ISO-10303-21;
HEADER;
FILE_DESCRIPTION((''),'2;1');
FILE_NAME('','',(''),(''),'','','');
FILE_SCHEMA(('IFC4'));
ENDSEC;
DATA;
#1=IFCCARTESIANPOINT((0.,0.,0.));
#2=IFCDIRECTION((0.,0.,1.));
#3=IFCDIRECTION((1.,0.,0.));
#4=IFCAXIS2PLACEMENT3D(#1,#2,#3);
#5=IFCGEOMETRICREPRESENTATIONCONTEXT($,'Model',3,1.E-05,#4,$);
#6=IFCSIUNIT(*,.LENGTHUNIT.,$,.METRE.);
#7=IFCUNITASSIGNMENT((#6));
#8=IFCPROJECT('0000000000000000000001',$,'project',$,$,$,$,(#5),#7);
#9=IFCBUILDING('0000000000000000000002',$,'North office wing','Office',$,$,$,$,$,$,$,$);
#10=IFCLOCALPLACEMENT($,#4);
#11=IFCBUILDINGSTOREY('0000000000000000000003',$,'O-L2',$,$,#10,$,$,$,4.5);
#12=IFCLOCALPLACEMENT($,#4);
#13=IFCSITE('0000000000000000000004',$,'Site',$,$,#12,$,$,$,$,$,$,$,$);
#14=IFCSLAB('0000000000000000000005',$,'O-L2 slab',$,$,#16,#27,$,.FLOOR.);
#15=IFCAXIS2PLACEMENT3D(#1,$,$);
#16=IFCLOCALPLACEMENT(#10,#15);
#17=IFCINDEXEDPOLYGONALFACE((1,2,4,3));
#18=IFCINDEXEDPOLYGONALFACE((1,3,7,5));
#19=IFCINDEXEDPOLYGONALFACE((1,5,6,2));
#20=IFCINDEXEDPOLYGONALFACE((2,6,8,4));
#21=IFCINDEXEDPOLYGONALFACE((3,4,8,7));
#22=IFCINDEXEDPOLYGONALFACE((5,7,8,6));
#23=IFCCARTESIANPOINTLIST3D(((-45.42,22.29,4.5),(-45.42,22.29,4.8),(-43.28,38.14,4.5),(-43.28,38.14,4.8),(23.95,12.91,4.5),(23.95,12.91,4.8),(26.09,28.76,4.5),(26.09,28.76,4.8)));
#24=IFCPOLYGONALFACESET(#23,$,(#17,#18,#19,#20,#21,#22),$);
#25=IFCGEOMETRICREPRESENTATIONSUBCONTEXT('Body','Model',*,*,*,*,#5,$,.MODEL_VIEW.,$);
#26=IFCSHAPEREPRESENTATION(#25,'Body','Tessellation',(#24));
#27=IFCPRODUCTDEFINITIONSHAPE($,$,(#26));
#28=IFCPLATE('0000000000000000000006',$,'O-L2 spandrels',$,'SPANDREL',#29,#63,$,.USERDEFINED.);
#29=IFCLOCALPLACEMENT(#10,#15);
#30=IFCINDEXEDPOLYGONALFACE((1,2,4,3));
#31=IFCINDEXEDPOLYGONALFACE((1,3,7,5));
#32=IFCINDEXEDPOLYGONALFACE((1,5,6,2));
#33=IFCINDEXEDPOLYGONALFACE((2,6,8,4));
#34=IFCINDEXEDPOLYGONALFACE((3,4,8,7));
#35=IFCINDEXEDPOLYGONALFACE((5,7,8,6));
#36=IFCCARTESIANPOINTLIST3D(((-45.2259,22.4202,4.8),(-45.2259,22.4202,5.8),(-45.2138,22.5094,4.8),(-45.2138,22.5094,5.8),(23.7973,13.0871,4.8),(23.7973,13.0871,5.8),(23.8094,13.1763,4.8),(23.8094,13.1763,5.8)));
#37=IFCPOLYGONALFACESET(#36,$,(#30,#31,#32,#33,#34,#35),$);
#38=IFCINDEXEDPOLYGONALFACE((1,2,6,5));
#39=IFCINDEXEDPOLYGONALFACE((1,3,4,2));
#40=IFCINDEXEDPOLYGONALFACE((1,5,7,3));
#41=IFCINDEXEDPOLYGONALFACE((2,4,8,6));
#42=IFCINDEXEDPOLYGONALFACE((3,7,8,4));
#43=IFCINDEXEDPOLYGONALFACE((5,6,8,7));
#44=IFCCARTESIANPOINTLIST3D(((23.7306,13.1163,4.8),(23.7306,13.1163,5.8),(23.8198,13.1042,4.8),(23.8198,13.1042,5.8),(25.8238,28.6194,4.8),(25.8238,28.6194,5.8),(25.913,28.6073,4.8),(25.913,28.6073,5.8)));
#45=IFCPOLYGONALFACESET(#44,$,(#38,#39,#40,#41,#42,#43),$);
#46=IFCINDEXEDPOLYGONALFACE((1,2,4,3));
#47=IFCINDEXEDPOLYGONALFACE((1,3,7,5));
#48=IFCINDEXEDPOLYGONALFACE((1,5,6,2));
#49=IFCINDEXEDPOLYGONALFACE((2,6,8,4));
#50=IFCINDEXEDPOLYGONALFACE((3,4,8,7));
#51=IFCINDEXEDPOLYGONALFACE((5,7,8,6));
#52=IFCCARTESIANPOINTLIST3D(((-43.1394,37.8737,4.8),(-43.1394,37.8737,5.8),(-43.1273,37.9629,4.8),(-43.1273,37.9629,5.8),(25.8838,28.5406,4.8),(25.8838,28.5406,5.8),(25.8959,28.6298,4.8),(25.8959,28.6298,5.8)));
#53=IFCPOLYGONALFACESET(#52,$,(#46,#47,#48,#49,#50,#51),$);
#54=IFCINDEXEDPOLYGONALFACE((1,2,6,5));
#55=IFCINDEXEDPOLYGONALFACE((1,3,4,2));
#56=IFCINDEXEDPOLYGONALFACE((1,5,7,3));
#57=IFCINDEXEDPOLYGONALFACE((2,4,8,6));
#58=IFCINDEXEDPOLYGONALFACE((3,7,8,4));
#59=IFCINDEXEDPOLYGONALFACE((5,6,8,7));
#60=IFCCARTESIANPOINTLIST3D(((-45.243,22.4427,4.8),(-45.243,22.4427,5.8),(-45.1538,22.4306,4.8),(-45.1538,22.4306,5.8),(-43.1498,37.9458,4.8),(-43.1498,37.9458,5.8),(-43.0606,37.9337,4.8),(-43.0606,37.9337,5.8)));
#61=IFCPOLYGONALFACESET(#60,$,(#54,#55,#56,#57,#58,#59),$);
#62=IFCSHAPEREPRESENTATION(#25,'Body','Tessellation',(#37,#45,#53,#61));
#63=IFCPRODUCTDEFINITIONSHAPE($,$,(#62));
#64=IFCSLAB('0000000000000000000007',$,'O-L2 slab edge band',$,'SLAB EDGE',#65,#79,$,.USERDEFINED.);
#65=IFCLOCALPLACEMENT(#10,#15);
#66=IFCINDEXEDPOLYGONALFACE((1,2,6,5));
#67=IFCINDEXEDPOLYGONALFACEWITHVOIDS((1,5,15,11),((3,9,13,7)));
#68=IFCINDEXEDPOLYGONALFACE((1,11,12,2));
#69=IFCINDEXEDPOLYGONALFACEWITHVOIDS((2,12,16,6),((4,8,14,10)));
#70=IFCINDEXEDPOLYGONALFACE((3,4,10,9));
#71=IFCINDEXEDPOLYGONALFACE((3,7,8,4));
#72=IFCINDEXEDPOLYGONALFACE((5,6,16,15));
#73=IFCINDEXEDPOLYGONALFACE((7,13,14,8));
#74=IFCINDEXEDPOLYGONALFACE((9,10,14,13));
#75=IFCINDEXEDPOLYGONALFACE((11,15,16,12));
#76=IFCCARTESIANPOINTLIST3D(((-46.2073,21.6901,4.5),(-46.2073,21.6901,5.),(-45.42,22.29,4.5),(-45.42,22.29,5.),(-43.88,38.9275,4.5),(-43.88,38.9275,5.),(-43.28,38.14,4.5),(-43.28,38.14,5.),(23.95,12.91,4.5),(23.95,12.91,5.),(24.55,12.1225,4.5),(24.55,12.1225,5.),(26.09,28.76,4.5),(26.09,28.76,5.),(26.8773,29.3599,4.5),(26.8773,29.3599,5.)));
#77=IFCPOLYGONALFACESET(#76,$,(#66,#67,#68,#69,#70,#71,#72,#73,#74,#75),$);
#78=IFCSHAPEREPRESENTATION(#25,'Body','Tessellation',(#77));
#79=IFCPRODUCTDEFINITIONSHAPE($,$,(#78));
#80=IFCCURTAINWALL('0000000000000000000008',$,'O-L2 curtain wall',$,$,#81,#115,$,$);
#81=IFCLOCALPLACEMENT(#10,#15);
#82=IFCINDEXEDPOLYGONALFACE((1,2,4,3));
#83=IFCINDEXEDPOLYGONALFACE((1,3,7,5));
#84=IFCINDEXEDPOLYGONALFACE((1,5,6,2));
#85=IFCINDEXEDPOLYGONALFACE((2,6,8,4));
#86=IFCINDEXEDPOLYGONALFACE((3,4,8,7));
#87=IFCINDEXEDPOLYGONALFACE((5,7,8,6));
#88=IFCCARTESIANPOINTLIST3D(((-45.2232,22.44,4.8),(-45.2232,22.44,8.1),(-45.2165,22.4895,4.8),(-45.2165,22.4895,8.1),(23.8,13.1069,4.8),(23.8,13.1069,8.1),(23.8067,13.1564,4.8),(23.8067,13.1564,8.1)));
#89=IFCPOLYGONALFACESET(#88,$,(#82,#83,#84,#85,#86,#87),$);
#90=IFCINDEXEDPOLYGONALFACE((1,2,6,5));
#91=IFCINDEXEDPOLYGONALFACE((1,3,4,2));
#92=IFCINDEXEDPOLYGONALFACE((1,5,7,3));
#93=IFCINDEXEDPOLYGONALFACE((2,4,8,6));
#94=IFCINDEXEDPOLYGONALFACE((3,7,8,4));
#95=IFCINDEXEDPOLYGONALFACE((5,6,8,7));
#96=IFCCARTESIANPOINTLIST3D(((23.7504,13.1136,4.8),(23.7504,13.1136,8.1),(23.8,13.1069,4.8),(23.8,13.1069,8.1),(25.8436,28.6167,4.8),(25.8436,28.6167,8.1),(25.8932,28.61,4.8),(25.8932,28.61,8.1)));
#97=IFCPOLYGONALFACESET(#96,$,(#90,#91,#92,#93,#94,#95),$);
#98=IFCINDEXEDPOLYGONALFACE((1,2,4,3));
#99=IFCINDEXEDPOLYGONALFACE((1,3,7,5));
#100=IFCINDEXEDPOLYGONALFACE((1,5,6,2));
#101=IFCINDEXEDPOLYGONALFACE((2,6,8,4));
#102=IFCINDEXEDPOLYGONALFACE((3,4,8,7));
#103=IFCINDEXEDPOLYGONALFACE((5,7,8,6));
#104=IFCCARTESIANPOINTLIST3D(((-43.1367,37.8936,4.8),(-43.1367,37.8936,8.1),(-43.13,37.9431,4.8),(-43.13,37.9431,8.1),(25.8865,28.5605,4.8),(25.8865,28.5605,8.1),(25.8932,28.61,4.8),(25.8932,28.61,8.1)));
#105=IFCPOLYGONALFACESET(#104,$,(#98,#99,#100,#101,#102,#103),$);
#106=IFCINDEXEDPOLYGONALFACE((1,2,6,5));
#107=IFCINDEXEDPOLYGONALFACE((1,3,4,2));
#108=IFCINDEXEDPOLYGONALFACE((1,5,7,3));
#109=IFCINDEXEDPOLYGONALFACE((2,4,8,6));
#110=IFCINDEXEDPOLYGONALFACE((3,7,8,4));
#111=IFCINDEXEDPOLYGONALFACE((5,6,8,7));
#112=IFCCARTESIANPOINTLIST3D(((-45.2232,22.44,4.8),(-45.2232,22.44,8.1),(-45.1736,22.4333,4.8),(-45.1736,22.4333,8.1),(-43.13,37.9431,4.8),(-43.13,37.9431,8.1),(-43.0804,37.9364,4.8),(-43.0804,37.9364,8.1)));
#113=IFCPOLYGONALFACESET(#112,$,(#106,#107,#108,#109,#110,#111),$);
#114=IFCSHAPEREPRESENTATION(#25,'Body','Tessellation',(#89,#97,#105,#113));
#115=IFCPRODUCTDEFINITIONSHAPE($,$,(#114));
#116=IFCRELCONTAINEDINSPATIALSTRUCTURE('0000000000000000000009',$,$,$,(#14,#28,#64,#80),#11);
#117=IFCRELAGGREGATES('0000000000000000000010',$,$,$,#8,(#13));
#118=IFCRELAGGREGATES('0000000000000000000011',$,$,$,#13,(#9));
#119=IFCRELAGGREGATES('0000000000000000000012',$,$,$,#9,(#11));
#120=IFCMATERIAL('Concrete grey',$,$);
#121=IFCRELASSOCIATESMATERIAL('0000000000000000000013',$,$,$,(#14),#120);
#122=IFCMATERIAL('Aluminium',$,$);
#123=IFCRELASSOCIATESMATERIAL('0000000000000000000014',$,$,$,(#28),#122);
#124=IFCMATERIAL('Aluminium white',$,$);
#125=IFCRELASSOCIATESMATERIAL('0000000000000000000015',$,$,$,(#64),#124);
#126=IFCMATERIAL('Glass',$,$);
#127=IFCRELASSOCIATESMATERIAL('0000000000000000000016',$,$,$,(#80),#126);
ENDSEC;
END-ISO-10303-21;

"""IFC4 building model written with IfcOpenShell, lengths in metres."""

from ifc_helpers import new_model, si_unit, frame, origin_with_axes, place, context, subcontext, project, spatial, polyline, outline, extrude, material, element, save


model = new_model("IFC4")

# Units and contexts
model_context = context("Model", 3, precision=1e-05, world=origin_with_axes())
body_context = subcontext(model_context, "Body", "Model", "MODEL_VIEW")
ifc_project = project(units=[si_unit("LENGTHUNIT", "METRE")], contexts=[model_context])

# Site, building, storey
site_placement = place(None, origin_with_axes())
site = spatial("IfcSite", under=ifc_project, at=site_placement, Name="Site")
building = spatial("IfcBuilding", under=site, Name="North office wing", Description="Office")
storey_placement = place(None, origin_with_axes())
storey = spatial("IfcBuildingStorey", under=building, at=storey_placement, Name="O-L2", Elevation=4.5)

# Shared definitions
ifc_material_1 = material(Name="Aluminium")

# Slab
ifc_material_2 = material(Name="Concrete grey")
slab_1_placement = place(storey_placement, origin_with_axes())
element("IfcSlab", 1, at=slab_1_placement, inside=storey, material=ifc_material_2, Name="O-L2 slab", PredefinedType="FLOOR", context=body_context, shape_type="SweptSolid", body=[
    extrude(outline(polyline([(-45.42, 22.29), (23.95, 12.91), (26.09, 28.76), (-43.28, 38.14), (-45.42, 22.29)])), frame((0.0, 0.0, 4.5), z_axis=(0.0, 0.0, 1.0), x_axis=(1.0, 0.0, 0.0)), (0.0, 0.0, 1.0), 0.3),
])

# Plate
plate_placement = place(storey_placement, origin_with_axes())
element("IfcPlate", 2, at=plate_placement, inside=storey, material=ifc_material_1, Name="O-L2 spandrels", ObjectType="SPANDREL", PredefinedType="USERDEFINED", context=body_context, shape_type="SweptSolid", body=[
    extrude(outline(polyline([(-45.2259, 22.4202), (23.7973, 13.0871), (23.8094, 13.1763), (-45.2138, 22.5094), (-45.2259, 22.4202)])), frame((0.0, 0.0, 4.8), z_axis=(0.0, 0.0, 1.0), x_axis=(1.0, 0.0, 0.0)), (0.0, 0.0, 1.0), 1.0),
    extrude(outline(polyline([(23.8198, 13.1042), (25.913, 28.6073), (25.8238, 28.6194), (23.7306, 13.1163), (23.8198, 13.1042)])), frame((0.0, 0.0, 4.8), z_axis=(0.0, 0.0, 1.0), x_axis=(1.0, 0.0, 0.0)), (0.0, 0.0, 1.0), 1.0),
    extrude(outline(polyline([(25.8959, 28.6298), (-43.1273, 37.9629), (-43.1394, 37.8737), (25.8838, 28.5406), (25.8959, 28.6298)])), frame((0.0, 0.0, 4.8), z_axis=(0.0, 0.0, 1.0), x_axis=(1.0, 0.0, 0.0)), (0.0, 0.0, 1.0), 1.0),
    extrude(outline(polyline([(-43.1498, 37.9458), (-45.243, 22.4427), (-45.1538, 22.4306), (-43.0606, 37.9337), (-43.1498, 37.9458)])), frame((0.0, 0.0, 4.8), z_axis=(0.0, 0.0, 1.0), x_axis=(1.0, 0.0, 0.0)), (0.0, 0.0, 1.0), 1.0),
])

# Slab
ifc_material_3 = material(Name="Aluminium white")
slab_2_placement = place(storey_placement, origin_with_axes())
element("IfcSlab", 3, at=slab_2_placement, inside=storey, material=ifc_material_3, Name="O-L2 slab edge band", ObjectType="SLAB EDGE", PredefinedType="USERDEFINED", context=body_context, shape_type="SweptSolid", body=[
    extrude(outline(polyline([(-46.2073, 21.6901), (24.55, 12.1225), (26.8773, 29.3599), (-43.88, 38.9275), (-46.2073, 21.6901)]), holes=[polyline([(-45.42, 22.29), (23.95, 12.91), (26.09, 28.76), (-43.28, 38.14), (-45.42, 22.29)])]), frame((0.0, 0.0, 4.5), z_axis=(0.0, 0.0, 1.0), x_axis=(1.0, 0.0, 0.0)), (0.0, 0.0, 1.0), 0.5),
])

# Curtain wall
ifc_material_4 = material(Name="Glass")
curtain_wall_placement = place(storey_placement, origin_with_axes())
element("IfcCurtainWall", 4, at=curtain_wall_placement, inside=storey, material=ifc_material_4, Name="O-L2 curtain wall", context=body_context, shape_type="SweptSolid", body=[
    extrude(outline(polyline([(-45.2232, 22.44), (23.8, 13.1069), (23.8067, 13.1564), (-45.2165, 22.4895), (-45.2232, 22.44)])), frame((0.0, 0.0, 4.8), z_axis=(0.0, 0.0, 1.0), x_axis=(1.0, 0.0, 0.0)), (0.0, 0.0, 1.0), 3.3),
    extrude(outline(polyline([(23.8, 13.1069), (25.8932, 28.61), (25.8436, 28.6167), (23.7504, 13.1136), (23.8, 13.1069)])), frame((0.0, 0.0, 4.8), z_axis=(0.0, 0.0, 1.0), x_axis=(1.0, 0.0, 0.0)), (0.0, 0.0, 1.0), 3.3),
    extrude(outline(polyline([(25.8932, 28.61), (-43.13, 37.9431), (-43.1367, 37.8936), (25.8865, 28.5605), (25.8932, 28.61)])), frame((0.0, 0.0, 4.8), z_axis=(0.0, 0.0, 1.0), x_axis=(1.0, 0.0, 0.0)), (0.0, 0.0, 1.0), 3.3),
    extrude(outline(polyline([(-43.13, 37.9431), (-45.2232, 22.44), (-45.1736, 22.4333), (-43.0804, 37.9364), (-43.13, 37.9431)])), frame((0.0, 0.0, 4.8), z_axis=(0.0, 0.0, 1.0), x_axis=(1.0, 0.0, 0.0)), (0.0, 0.0, 1.0), 3.3),
])

save(model, "model.ifc")
